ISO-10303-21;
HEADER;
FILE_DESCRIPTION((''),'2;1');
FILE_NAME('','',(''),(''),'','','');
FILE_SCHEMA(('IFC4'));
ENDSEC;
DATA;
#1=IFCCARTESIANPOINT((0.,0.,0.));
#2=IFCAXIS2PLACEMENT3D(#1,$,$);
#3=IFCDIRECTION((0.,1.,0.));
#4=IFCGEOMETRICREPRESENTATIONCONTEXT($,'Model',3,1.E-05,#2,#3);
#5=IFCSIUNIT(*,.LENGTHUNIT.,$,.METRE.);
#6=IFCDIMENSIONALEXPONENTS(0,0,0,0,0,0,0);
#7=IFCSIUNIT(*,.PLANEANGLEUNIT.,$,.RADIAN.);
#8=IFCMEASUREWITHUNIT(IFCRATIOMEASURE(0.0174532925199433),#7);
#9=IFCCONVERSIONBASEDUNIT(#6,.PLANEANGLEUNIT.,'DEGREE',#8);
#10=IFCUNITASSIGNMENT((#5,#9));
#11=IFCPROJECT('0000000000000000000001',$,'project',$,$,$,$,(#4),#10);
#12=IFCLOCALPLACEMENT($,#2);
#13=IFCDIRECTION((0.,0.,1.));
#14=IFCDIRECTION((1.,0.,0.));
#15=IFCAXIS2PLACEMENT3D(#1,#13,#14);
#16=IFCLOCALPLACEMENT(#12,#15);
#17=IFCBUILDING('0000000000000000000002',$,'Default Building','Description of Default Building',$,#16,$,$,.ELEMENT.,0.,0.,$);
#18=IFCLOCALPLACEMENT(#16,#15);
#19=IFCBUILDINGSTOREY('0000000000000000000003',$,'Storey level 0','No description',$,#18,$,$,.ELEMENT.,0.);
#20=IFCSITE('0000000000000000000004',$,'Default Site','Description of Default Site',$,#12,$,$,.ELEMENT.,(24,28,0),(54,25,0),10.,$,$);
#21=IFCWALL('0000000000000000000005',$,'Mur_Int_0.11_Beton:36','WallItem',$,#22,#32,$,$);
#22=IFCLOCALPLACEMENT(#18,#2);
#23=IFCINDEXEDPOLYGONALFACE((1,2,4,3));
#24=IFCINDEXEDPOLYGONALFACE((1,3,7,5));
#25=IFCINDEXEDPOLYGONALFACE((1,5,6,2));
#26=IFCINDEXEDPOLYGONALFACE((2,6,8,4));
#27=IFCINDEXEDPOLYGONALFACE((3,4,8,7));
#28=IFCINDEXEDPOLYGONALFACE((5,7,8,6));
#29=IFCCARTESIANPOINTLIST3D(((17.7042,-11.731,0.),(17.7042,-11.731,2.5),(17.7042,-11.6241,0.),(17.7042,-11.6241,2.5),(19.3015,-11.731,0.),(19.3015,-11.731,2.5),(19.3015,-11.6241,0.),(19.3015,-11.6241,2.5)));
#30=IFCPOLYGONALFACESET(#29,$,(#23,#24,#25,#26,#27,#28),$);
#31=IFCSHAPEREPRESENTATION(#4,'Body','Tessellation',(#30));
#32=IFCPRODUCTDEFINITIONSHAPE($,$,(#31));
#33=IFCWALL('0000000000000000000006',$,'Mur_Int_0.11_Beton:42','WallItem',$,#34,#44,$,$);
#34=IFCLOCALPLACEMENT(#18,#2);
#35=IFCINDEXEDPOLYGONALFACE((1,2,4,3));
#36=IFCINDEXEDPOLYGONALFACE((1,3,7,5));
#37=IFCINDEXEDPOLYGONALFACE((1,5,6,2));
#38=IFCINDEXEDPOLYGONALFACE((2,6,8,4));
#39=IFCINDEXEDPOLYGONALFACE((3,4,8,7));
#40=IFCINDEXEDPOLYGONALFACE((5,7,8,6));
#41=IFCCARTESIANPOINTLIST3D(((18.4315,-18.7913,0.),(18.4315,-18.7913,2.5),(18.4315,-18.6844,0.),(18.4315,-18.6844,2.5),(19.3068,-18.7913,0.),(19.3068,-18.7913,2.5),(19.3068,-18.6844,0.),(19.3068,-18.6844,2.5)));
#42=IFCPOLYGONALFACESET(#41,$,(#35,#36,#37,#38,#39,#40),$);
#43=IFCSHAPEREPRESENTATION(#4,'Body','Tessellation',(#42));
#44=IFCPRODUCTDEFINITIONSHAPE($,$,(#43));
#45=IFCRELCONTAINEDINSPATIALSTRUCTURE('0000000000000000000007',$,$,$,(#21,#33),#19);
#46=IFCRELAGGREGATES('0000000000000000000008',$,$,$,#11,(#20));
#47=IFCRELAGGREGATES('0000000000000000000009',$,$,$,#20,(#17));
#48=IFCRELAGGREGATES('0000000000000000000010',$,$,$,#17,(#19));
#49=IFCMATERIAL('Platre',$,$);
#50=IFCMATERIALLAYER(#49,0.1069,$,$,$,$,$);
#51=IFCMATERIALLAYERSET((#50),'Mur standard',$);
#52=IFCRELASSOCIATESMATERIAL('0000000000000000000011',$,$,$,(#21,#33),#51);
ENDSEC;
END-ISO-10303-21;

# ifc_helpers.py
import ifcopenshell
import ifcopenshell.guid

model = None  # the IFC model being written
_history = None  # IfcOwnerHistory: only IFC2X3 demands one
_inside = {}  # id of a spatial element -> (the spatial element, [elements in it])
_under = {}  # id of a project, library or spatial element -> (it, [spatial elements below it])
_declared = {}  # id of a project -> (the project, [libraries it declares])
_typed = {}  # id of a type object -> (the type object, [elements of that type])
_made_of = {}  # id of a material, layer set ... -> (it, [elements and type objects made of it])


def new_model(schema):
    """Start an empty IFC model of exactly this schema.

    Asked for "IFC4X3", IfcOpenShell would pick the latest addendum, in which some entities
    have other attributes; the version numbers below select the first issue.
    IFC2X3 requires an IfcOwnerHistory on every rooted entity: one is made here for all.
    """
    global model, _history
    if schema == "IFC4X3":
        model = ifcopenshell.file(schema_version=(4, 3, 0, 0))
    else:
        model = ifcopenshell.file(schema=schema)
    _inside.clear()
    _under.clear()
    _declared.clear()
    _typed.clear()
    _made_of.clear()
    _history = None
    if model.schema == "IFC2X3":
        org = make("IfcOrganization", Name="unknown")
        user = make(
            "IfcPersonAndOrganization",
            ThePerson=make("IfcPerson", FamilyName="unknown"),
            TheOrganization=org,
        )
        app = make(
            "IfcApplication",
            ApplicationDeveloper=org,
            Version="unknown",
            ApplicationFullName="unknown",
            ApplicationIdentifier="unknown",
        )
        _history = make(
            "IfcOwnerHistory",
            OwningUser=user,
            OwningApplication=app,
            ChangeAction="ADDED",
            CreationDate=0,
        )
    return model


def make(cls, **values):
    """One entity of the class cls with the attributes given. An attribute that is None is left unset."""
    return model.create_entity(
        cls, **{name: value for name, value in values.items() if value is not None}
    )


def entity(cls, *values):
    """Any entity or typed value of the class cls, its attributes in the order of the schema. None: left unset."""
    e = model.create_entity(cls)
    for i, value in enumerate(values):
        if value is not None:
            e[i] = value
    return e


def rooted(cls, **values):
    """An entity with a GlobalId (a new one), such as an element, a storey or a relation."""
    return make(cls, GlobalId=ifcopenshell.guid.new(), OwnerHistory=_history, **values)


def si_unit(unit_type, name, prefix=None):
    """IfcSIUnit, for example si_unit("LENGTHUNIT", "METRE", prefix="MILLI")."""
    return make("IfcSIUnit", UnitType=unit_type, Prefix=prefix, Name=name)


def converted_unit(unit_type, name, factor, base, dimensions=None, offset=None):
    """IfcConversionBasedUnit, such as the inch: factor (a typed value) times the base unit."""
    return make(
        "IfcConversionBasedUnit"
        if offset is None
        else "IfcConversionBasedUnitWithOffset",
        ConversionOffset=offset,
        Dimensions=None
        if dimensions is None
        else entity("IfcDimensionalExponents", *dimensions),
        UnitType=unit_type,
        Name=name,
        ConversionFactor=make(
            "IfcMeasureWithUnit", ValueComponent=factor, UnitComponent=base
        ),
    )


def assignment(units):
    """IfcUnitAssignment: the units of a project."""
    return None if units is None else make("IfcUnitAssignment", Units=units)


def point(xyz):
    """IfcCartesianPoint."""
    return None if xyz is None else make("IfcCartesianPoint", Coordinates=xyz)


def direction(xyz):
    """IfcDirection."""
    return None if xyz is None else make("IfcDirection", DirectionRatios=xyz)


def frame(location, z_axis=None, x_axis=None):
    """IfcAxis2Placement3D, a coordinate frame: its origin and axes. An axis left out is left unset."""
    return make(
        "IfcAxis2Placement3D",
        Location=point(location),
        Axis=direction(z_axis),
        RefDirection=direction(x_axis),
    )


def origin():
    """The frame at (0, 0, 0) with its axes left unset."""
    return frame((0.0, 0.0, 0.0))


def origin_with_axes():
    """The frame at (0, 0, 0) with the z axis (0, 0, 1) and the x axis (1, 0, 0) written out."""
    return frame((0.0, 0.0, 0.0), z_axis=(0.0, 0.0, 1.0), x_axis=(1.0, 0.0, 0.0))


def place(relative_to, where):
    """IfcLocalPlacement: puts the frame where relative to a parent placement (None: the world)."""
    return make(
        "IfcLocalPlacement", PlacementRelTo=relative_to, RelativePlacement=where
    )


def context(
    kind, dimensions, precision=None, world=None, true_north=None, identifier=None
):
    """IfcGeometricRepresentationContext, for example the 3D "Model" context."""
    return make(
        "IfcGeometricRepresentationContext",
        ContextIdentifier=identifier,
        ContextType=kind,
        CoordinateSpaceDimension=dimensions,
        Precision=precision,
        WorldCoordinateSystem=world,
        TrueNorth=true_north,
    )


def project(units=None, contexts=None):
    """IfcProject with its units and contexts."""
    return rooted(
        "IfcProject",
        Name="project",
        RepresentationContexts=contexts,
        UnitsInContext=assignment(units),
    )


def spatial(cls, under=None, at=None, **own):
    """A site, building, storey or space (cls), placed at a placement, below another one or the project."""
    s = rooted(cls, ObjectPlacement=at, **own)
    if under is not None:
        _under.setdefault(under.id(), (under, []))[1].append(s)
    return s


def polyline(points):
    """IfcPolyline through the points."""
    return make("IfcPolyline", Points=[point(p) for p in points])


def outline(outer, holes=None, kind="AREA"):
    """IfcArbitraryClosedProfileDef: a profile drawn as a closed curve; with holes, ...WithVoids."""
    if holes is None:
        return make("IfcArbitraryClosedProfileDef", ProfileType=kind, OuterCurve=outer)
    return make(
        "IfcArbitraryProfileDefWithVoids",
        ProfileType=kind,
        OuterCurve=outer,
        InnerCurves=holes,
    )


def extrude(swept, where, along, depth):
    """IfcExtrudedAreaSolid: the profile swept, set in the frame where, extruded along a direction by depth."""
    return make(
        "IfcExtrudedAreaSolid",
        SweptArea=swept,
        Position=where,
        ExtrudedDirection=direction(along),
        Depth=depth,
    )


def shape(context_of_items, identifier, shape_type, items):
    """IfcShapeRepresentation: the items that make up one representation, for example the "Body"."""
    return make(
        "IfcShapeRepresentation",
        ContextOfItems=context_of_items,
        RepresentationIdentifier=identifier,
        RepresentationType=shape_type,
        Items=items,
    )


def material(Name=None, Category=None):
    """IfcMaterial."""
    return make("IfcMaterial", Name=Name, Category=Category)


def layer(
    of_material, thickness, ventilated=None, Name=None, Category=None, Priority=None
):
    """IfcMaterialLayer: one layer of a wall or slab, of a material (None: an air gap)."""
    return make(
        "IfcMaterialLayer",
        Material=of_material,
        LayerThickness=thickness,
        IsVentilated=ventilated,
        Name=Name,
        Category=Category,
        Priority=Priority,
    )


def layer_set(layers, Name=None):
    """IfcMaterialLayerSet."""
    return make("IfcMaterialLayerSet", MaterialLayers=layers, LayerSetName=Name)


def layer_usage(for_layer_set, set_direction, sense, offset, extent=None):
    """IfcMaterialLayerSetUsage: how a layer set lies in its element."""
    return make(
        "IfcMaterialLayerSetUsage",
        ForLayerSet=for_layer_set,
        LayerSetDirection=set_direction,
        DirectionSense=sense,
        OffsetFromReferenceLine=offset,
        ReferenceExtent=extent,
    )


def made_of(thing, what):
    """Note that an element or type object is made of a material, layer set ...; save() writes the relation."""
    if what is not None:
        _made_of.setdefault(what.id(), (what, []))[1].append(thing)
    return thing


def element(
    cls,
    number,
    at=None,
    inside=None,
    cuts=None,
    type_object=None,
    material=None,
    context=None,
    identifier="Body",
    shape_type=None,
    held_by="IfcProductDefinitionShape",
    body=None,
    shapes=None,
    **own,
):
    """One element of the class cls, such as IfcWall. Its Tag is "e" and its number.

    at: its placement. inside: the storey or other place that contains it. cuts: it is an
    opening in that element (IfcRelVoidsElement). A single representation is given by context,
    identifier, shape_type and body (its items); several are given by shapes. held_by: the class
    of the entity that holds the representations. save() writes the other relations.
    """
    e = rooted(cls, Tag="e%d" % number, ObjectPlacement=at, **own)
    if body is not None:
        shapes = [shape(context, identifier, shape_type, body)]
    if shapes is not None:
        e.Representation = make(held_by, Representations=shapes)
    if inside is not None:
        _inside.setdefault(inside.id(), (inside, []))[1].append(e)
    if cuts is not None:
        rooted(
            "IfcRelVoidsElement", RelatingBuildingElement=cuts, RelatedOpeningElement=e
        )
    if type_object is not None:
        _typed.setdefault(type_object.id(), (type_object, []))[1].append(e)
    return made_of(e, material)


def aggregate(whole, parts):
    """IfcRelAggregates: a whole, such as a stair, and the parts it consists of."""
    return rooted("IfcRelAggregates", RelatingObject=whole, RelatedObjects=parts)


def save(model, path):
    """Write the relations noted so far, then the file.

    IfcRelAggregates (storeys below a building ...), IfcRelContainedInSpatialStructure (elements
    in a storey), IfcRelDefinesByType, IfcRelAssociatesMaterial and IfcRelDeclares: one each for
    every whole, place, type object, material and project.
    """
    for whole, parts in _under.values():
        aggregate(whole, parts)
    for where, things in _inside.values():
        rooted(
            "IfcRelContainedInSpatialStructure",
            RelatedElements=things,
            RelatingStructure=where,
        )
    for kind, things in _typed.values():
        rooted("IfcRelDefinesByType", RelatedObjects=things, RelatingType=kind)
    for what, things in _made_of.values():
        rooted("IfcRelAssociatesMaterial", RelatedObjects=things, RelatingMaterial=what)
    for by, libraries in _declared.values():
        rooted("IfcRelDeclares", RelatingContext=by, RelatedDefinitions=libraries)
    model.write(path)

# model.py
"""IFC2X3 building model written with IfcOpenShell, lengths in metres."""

from ifc_helpers import new_model, entity, si_unit, converted_unit, direction, frame, origin, origin_with_axes, place, context, project, spatial, polyline, outline, extrude, material, layer, layer_set, layer_usage, element, save


model = new_model("IFC2X3")

# Units and contexts
model_context = context("Model", 3, precision=1e-05, world=origin(), true_north=direction((0.0, 1.0, 0.0)))
ifc_project = project(units=[si_unit("LENGTHUNIT", "METRE"), converted_unit("PLANEANGLEUNIT", "DEGREE", entity("IfcRatioMeasure", 0.0174532925199433), si_unit("PLANEANGLEUNIT", "RADIAN"), dimensions=[0, 0, 0, 0, 0, 0, 0])], contexts=[model_context])

# Site, building, storey
site_placement = place(None, origin())
site = spatial("IfcSite", under=ifc_project, at=site_placement, Name="Default Site", Description="Description of Default Site", CompositionType="ELEMENT", RefLatitude=(24, 28, 0), RefLongitude=(54, 25, 0), RefElevation=10.0)
building_placement = place(site_placement, origin_with_axes())
building = spatial("IfcBuilding", under=site, at=building_placement, Name="Default Building", Description="Description of Default Building", CompositionType="ELEMENT", ElevationOfRefHeight=0.0, ElevationOfTerrain=0.0)
storey_placement = place(building_placement, origin_with_axes())
storey = spatial("IfcBuildingStorey", under=building, at=storey_placement, Name="Storey level 0", Description="No description", CompositionType="ELEMENT", Elevation=0.0)

# Walls
ifc_material_1 = material(Name="Platre")
ifc_layer_1 = layer(ifc_material_1, 0.1069)
ifc_layer_set_1 = layer_set([ifc_layer_1], Name="Mur standard")
ifc_layer_usage_1 = layer_usage(ifc_layer_set_1, "AXIS2", "NEGATIVE", 0.1069)
wall_1_placement = place(storey_placement, frame((17.7042, -11.6776, 0.0), z_axis=(0.0, 0.0, 1.0), x_axis=(1.0, 0.0, 0.0)))
element("IfcWall", 1, at=wall_1_placement, inside=storey, material=ifc_layer_usage_1, Name="Mur_Int_0.11_Beton:36", Description="WallItem", context=model_context, shape_type="SweptSolid", body=[
    extrude(outline(polyline([(0.0, 0.0535), (0.0, -0.0534), (1.5973, -0.0534), (1.5973, 0.0535), (0.0, 0.0535)])), origin(), (0.0, 0.0, 1.0), 2.5),
])
wall_2_placement = place(storey_placement, frame((18.4315, -18.7379, 0.0), z_axis=(0.0, 0.0, 1.0), x_axis=(1.0, 0.0, 0.0)))
element("IfcWall", 2, at=wall_2_placement, inside=storey, material=ifc_layer_usage_1, Name="Mur_Int_0.11_Beton:42", Description="WallItem", context=model_context, shape_type="SweptSolid", body=[
    extrude(outline(polyline([(0.0, 0.0535), (0.0, -0.0534), (0.8753, -0.0534), (0.8753, 0.0535), (0.0, 0.0535)])), origin(), (0.0, 0.0, 1.0), 2.5),
])

save(model, "model.ifc")
